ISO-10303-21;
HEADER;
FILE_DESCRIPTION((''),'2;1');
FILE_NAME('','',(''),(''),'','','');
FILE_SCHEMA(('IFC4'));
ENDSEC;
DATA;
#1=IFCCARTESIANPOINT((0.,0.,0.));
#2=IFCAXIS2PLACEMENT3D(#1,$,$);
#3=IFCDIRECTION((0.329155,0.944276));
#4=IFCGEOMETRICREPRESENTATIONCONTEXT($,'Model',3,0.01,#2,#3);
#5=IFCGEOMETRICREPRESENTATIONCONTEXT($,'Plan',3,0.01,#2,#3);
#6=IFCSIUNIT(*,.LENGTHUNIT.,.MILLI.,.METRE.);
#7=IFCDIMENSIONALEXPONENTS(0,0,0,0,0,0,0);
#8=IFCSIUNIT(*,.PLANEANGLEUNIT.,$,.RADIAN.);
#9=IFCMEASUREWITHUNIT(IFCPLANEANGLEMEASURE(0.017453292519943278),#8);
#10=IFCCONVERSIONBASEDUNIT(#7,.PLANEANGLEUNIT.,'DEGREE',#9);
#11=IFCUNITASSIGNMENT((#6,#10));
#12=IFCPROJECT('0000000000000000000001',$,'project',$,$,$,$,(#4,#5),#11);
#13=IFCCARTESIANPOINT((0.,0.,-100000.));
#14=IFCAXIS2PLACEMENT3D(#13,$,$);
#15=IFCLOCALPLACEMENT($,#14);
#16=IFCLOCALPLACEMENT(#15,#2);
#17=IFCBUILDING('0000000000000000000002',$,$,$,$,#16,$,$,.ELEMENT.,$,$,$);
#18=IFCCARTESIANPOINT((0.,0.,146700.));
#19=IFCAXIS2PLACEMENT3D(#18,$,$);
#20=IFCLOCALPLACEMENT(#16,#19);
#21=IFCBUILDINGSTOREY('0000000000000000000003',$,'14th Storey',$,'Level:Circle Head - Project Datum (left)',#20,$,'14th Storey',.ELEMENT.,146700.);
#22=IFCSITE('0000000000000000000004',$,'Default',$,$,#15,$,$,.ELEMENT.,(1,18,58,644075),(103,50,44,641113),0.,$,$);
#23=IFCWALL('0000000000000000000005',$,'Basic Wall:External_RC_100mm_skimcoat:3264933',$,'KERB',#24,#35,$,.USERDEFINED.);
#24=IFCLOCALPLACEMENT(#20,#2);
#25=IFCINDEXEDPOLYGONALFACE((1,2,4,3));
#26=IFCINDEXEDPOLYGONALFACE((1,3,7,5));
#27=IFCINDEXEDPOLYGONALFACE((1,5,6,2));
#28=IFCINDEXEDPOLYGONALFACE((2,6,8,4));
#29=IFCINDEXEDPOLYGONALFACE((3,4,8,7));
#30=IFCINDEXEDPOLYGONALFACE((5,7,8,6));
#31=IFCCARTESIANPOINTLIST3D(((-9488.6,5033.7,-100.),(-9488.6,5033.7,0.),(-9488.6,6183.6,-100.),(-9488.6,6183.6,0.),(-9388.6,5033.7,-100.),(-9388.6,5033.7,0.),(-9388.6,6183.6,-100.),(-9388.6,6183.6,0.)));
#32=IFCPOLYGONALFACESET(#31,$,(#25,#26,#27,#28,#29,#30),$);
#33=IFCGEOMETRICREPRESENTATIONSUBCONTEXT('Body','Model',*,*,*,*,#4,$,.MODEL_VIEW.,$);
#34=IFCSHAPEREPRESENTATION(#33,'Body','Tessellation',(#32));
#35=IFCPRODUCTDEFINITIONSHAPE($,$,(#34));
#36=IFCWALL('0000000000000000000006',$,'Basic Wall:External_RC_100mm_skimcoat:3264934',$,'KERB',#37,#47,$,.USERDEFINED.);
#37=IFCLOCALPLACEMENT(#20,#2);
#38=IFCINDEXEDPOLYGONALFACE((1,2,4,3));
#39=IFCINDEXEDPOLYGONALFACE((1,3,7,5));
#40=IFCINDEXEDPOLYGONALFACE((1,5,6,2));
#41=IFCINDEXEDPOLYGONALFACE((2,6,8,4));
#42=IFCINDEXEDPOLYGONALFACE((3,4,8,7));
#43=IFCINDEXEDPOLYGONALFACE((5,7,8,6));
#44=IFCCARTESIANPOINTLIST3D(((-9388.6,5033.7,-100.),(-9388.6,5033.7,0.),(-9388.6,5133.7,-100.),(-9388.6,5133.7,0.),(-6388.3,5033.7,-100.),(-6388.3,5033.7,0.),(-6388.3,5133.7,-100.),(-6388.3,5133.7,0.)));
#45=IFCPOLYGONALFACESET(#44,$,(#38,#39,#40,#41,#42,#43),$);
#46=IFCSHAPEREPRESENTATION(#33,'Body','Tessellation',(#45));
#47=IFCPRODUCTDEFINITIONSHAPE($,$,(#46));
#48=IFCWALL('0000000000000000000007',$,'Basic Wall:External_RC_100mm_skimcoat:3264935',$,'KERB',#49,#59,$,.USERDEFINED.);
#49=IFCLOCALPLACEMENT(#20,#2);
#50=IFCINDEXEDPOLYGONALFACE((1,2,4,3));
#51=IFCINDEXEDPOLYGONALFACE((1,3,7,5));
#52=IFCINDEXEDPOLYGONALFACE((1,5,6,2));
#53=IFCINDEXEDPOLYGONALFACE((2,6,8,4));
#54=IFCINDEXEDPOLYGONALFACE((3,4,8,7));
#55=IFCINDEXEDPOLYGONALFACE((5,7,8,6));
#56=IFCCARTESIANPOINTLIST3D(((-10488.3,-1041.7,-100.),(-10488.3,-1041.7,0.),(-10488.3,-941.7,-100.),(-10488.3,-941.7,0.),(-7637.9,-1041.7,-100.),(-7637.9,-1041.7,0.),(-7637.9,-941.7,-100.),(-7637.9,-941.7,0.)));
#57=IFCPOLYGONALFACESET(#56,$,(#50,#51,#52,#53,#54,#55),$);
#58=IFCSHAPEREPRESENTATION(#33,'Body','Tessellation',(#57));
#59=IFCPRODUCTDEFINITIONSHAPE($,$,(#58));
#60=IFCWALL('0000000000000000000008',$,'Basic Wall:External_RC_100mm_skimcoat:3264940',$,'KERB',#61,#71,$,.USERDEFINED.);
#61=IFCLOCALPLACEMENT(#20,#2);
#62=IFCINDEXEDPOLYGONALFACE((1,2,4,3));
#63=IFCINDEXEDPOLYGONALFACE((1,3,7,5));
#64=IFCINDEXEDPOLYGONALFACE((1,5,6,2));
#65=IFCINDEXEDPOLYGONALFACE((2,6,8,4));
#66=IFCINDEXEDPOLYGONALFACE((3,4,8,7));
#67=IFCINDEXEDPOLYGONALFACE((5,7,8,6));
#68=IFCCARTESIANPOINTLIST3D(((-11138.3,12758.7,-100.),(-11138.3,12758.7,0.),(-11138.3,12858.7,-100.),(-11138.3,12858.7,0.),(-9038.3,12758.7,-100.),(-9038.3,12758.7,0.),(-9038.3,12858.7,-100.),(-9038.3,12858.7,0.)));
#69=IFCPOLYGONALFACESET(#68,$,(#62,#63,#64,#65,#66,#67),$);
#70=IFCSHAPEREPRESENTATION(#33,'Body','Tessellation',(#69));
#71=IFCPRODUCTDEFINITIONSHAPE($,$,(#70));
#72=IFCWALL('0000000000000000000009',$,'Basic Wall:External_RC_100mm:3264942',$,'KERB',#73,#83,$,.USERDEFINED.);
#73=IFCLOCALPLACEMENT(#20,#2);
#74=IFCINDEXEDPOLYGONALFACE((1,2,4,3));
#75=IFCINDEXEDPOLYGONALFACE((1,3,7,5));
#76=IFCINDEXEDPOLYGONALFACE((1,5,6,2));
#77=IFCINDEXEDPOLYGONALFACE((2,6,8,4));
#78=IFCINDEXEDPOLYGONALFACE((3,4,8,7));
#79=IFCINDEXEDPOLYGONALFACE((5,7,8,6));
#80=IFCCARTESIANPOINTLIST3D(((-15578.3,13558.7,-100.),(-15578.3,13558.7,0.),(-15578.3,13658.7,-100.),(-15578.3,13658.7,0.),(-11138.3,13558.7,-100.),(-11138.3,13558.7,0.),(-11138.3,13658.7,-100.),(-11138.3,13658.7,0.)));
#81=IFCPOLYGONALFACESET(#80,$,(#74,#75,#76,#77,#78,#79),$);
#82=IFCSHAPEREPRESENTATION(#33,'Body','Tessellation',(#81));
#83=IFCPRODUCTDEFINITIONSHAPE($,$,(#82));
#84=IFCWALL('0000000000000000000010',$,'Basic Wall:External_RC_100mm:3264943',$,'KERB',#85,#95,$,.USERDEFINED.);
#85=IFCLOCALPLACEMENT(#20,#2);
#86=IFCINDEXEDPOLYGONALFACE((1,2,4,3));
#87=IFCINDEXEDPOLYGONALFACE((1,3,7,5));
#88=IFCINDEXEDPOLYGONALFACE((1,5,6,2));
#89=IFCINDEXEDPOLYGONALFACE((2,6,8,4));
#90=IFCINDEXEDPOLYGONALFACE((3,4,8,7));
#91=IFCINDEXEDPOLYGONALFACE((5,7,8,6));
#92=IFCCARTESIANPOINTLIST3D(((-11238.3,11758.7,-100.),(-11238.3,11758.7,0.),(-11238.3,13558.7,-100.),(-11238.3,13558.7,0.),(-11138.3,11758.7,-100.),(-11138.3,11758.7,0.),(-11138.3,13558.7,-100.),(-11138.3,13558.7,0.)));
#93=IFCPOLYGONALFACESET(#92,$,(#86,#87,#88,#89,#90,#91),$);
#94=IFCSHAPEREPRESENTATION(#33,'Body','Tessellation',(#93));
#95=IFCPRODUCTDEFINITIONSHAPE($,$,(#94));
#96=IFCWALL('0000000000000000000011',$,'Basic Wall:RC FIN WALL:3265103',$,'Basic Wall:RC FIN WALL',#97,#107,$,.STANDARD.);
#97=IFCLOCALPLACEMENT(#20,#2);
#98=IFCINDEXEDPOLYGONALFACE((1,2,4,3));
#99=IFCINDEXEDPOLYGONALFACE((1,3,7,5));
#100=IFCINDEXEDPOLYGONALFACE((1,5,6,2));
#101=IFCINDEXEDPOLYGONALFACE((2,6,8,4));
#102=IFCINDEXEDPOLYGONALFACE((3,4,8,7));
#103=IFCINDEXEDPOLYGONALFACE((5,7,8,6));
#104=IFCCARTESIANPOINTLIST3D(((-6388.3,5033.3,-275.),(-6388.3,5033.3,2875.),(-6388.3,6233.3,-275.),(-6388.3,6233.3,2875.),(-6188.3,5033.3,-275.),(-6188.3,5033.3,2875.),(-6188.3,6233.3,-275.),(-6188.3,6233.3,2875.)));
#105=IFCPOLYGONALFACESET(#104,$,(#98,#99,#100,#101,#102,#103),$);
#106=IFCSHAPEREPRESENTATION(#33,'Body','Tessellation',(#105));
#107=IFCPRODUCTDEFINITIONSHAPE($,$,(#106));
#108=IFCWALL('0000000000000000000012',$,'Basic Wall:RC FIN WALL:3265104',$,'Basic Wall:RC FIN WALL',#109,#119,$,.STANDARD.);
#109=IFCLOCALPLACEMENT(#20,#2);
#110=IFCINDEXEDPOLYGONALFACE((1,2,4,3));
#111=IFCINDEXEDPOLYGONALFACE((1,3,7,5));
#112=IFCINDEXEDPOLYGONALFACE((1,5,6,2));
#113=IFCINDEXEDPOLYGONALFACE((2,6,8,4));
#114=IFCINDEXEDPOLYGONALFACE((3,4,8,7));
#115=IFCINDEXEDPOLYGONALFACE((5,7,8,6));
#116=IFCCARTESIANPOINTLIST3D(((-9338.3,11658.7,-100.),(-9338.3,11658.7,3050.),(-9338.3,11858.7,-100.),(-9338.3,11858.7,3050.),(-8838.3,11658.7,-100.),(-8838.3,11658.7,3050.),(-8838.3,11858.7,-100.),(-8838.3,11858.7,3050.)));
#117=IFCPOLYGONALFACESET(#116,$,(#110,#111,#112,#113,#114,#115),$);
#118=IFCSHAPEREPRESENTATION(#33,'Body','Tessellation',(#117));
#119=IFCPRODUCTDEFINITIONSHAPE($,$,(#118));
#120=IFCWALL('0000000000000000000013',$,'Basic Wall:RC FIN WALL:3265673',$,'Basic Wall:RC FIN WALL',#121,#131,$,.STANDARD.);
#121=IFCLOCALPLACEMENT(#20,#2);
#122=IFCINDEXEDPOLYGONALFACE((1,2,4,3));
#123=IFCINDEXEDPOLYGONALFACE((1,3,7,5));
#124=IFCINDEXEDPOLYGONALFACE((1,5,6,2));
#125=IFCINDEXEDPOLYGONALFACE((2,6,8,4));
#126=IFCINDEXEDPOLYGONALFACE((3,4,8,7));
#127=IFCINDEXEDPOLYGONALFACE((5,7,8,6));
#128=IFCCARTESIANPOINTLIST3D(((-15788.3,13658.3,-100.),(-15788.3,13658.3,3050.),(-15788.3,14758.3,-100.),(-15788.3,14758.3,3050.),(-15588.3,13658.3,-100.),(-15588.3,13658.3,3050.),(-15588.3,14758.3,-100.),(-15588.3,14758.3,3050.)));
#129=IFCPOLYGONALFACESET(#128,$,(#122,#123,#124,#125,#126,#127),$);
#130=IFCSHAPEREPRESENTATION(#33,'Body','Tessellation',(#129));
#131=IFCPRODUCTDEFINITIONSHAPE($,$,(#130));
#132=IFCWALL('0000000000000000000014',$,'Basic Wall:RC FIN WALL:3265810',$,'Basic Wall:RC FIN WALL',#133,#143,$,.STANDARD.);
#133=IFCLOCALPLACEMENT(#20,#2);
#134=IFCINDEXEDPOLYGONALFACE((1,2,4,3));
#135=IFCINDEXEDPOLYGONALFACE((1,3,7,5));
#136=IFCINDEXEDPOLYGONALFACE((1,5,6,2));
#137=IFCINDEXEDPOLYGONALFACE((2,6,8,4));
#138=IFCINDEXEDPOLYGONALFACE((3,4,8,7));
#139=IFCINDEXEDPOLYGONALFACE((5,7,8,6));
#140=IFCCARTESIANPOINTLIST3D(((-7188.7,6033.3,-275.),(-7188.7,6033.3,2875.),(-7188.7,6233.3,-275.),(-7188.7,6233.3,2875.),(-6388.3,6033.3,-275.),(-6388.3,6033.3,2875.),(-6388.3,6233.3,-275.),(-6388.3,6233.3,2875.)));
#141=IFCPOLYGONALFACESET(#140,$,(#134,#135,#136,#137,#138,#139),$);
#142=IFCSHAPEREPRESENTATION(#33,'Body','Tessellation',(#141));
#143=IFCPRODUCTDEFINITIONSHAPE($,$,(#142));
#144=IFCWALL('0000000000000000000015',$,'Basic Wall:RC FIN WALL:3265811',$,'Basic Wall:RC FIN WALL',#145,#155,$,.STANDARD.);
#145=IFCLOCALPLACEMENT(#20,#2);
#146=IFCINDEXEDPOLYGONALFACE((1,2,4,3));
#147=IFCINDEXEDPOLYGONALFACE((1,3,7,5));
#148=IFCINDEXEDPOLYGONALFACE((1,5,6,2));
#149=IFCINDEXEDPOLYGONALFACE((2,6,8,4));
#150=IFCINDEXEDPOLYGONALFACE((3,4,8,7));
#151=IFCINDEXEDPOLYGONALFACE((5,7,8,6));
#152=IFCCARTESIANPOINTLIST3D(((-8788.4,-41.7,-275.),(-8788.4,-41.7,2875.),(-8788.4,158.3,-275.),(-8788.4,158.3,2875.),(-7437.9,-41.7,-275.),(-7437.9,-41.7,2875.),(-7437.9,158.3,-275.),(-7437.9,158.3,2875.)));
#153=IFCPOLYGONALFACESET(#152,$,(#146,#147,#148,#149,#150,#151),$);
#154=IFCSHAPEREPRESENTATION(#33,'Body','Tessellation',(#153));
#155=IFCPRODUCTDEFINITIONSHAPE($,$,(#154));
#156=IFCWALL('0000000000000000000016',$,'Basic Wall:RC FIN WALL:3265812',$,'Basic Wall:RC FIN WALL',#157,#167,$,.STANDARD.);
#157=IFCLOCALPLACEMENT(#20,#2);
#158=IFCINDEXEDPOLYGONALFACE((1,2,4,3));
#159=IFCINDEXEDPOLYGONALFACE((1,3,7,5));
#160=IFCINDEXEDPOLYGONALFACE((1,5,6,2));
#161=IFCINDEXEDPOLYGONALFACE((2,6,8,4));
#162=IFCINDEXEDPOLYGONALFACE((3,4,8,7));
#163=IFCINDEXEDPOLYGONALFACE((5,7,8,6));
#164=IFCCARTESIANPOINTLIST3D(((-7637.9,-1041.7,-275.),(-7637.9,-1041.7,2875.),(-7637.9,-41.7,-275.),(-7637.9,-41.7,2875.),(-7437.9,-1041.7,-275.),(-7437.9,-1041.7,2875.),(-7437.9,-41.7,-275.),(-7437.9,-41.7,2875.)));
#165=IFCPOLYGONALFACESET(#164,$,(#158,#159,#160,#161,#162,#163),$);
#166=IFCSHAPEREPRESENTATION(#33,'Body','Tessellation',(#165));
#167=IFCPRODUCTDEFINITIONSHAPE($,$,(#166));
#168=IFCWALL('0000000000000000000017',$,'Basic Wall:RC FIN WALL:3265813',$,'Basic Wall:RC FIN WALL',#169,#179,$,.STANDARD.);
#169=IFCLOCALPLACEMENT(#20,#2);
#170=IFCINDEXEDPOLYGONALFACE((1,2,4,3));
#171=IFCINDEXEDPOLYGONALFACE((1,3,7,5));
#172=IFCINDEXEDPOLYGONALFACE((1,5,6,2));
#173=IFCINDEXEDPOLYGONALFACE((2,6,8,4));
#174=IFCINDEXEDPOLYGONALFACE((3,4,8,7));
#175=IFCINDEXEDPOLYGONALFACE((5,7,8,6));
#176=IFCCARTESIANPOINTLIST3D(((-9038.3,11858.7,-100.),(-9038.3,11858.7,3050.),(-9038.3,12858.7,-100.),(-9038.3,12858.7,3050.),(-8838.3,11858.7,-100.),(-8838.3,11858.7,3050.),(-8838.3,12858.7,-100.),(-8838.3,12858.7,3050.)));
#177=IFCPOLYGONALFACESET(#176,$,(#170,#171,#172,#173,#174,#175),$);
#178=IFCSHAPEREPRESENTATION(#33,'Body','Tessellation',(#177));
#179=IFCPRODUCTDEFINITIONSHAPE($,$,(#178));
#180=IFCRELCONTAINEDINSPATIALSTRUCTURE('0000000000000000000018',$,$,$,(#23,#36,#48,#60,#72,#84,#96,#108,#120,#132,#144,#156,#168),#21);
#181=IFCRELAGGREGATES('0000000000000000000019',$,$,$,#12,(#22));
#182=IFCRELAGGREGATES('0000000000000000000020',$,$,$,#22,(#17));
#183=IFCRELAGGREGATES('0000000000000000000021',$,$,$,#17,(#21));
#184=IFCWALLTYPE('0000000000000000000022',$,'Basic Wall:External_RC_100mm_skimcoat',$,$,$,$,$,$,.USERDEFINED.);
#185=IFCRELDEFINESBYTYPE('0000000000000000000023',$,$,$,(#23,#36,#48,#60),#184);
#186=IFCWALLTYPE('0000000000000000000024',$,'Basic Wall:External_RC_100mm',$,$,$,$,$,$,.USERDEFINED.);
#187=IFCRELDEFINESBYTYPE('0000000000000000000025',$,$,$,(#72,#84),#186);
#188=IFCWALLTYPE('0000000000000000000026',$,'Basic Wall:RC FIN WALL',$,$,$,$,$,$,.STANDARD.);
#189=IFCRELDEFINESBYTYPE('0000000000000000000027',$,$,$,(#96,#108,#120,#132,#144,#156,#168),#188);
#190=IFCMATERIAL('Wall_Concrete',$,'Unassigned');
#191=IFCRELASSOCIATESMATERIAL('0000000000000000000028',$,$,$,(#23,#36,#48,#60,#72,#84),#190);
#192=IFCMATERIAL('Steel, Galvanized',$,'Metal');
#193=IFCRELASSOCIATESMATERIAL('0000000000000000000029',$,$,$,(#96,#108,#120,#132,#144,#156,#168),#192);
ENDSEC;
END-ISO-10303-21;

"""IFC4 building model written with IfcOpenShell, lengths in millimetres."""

from ifc_helpers import new_model, entity, si_unit, converted_unit, direction, frame, origin, place, context, subcontext, project, spatial, indexed_curve, outline, extrude, material, type_object, element, save


model = new_model("IFC4")

# Units and contexts
model_context = context("Model", 3, precision=0.01, world=origin(), true_north=direction((0.329155, 0.944276)))
plan_context = context("Plan", 3, precision=0.01, world=origin(), true_north=direction((0.329155, 0.944276)))
body_context = subcontext(model_context, "Body", "Model", "MODEL_VIEW")
ifc_project = project(units=[si_unit("LENGTHUNIT", "METRE", prefix="MILLI"), converted_unit("PLANEANGLEUNIT", "DEGREE", entity("IfcPlaneAngleMeasure", 0.017453292519943278), si_unit("PLANEANGLEUNIT", "RADIAN"), dimensions=[0, 0, 0, 0, 0, 0, 0])], contexts=[model_context, plan_context])

# Site, building, storey
site_placement = place(None, frame((0.0, 0.0, -100000.0)))
site = spatial("IfcSite", under=ifc_project, at=site_placement, Name="Default", CompositionType="ELEMENT", RefLatitude=(1, 18, 58, 644075), RefLongitude=(103, 50, 44, 641113), RefElevation=0.0)
building_placement = place(site_placement, origin())
building = spatial("IfcBuilding", under=site, at=building_placement, CompositionType="ELEMENT")
storey_placement = place(building_placement, frame((0.0, 0.0, 146700.0)))
storey = spatial("IfcBuildingStorey", under=building, at=storey_placement, Name="14th Storey", ObjectType="Level:Circle Head - Project Datum (left)", LongName="14th Storey", CompositionType="ELEMENT", Elevation=146700.0)

# Walls
ifc_material_1 = material(Name="Wall_Concrete", Category="Unassigned")
wall_type_1 = type_object("IfcWallType", Name="Basic Wall:External_RC_100mm_skimcoat", PredefinedType="USERDEFINED")
wall_1_placement = place(storey_placement, frame((-9438.6, 6183.6, -100.0), z_axis=(0.0, 0.0, 1.0), x_axis=(0.0, -1.0, 0.0)))
element("IfcWall", 1, at=wall_1_placement, inside=storey, type_object=wall_type_1, material=ifc_material_1, Name="Basic Wall:External_RC_100mm_skimcoat:3264933", ObjectType="KERB", PredefinedType="USERDEFINED", context=body_context, shape_type="SweptSolid", body=[
    extrude(outline(indexed_curve([(1149.9, 50.0), (0.0, 50.0), (0.0, -50.0), (1149.9, -50.0), (1149.9, 50.0)], self_intersect=False)), origin(), (0.0, 0.0, 1.0), 100.0),
])
wall_2_placement = place(storey_placement, frame((-9388.6, 5083.7, -100.0)))
element("IfcWall", 2, at=wall_2_placement, inside=storey, type_object=wall_type_1, material=ifc_material_1, Name="Basic Wall:External_RC_100mm_skimcoat:3264934", ObjectType="KERB", PredefinedType="USERDEFINED", context=body_context, shape_type="SweptSolid", body=[
    extrude(outline(indexed_curve([(3000.3, 50.0), (0.0, 50.0), (0.0, -50.0), (3000.3, -50.0), (3000.3, 50.0)], self_intersect=False)), origin(), (0.0, 0.0, 1.0), 100.0),
])
wall_3_placement = place(storey_placement, frame((-7637.9, -991.7, -100.0), z_axis=(0.0, 0.0, 1.0), x_axis=(-1.0, 0.0, 0.0)))
element("IfcWall", 3, at=wall_3_placement, inside=storey, type_object=wall_type_1, material=ifc_material_1, Name="Basic Wall:External_RC_100mm_skimcoat:3264935", ObjectType="KERB", PredefinedType="USERDEFINED", context=body_context, shape_type="SweptSolid", body=[
    extrude(outline(indexed_curve([(2850.5, 50.0), (0.0, 50.0), (0.0, -50.0), (2850.5, -50.0), (2850.5, 50.0)], self_intersect=False)), origin(), (0.0, 0.0, 1.0), 100.0),
])
wall_4_placement = place(storey_placement, frame((-9038.3, 12808.7, -100.0), z_axis=(0.0, 0.0, 1.0), x_axis=(-1.0, 0.0, 0.0)))
element("IfcWall", 4, at=wall_4_placement, inside=storey, type_object=wall_type_1, material=ifc_material_1, Name="Basic Wall:External_RC_100mm_skimcoat:3264940", ObjectType="KERB", PredefinedType="USERDEFINED", context=body_context, shape_type="SweptSolid", body=[
    extrude(outline(indexed_curve([(2100.0, 50.0), (0.0, 50.0), (0.0, -50.0), (2100.0, -50.0), (2100.0, 50.0)], self_intersect=False)), origin(), (0.0, 0.0, 1.0), 100.0),
])
wall_type_2 = type_object("IfcWallType", Name="Basic Wall:External_RC_100mm", PredefinedType="USERDEFINED")
wall_5_placement = place(storey_placement, frame((-15578.3, 13608.7, -100.0)))
element("IfcWall", 5, at=wall_5_placement, inside=storey, type_object=wall_type_2, material=ifc_material_1, Name="Basic Wall:External_RC_100mm:3264942", ObjectType="KERB", PredefinedType="USERDEFINED", context=body_context, shape_type="SweptSolid", body=[
    extrude(outline(indexed_curve([(4440.0, 50.0), (0.0, 50.0), (0.0, -50.0), (4440.0, -50.0), (4440.0, 50.0)], self_intersect=False)), origin(), (0.0, 0.0, 1.0), 100.0),
])
wall_6_placement = place(storey_placement, frame((-11188.3, 13558.7, -100.0), z_axis=(0.0, 0.0, 1.0), x_axis=(0.0, -1.0, 0.0)))
element("IfcWall", 6, at=wall_6_placement, inside=storey, type_object=wall_type_2, material=ifc_material_1, Name="Basic Wall:External_RC_100mm:3264943", ObjectType="KERB", PredefinedType="USERDEFINED", context=body_context, shape_type="SweptSolid", body=[
    extrude(outline(indexed_curve([(1800.0, 50.0), (0.0, 50.0), (0.0, -50.0), (1800.0, -50.0), (1800.0, 50.0)], self_intersect=False)), origin(), (0.0, 0.0, 1.0), 100.0),
])
ifc_material_2 = material(Name="Steel, Galvanized", Category="Metal")
wall_type_3 = type_object("IfcWallType", Name="Basic Wall:RC FIN WALL", PredefinedType="STANDARD")
wall_7_placement = place(storey_placement, frame((-6288.3, 6233.3, -275.0), z_axis=(0.0, 0.0, 1.0), x_axis=(0.0, -1.0, 0.0)))
element("IfcWall", 7, at=wall_7_placement, inside=storey, type_object=wall_type_3, material=ifc_material_2, Name="Basic Wall:RC FIN WALL:3265103", ObjectType="Basic Wall:RC FIN WALL", PredefinedType="STANDARD", context=body_context, shape_type="SweptSolid", body=[
    extrude(outline(indexed_curve([(1200.0, 100.0), (0.0, 100.0), (0.0, -100.0), (1200.0, -100.0), (1200.0, 100.0)], self_intersect=False)), origin(), (0.0, 0.0, 1.0), 3150.0),
])
wall_8_placement = place(storey_placement, frame((-9338.3, 11758.7, -100.0)))
element("IfcWall", 8, at=wall_8_placement, inside=storey, type_object=wall_type_3, material=ifc_material_2, Name="Basic Wall:RC FIN WALL:3265104", ObjectType="Basic Wall:RC FIN WALL", PredefinedType="STANDARD", context=body_context, shape_type="SweptSolid", body=[
    extrude(outline(indexed_curve([(500.0, 100.0), (0.0, 100.0), (0.0, -100.0), (500.0, -100.0), (500.0, 100.0)], self_intersect=False)), origin(), (0.0, 0.0, 1.0), 3150.0),
])
wall_9_placement = place(storey_placement, frame((-15688.3, 13658.3, -100.0), z_axis=(0.0, 0.0, 1.0), x_axis=(0.0, 1.0, 0.0)))
element("IfcWall", 9, at=wall_9_placement, inside=storey, type_object=wall_type_3, material=ifc_material_2, Name="Basic Wall:RC FIN WALL:3265673", ObjectType="Basic Wall:RC FIN WALL", PredefinedType="STANDARD", context=body_context, shape_type="SweptSolid", body=[
    extrude(outline(indexed_curve([(1100.0, 100.0), (0.0, 100.0), (0.0, -100.0), (1100.0, -100.0), (1100.0, 100.0)], self_intersect=False)), origin(), (0.0, 0.0, 1.0), 3150.0),
])
wall_10_placement = place(storey_placement, frame((-7188.7, 6133.3, -275.0)))
element("IfcWall", 10, at=wall_10_placement, inside=storey, type_object=wall_type_3, material=ifc_material_2, Name="Basic Wall:RC FIN WALL:3265810", ObjectType="Basic Wall:RC FIN WALL", PredefinedType="STANDARD", context=body_context, shape_type="SweptSolid", body=[
    extrude(outline(indexed_curve([(800.3, 100.0), (0.0, 100.0), (0.0, -100.0), (800.3, -100.0), (800.3, 100.0)], self_intersect=False)), origin(), (0.0, 0.0, 1.0), 3150.0),
])
wall_11_placement = place(storey_placement, frame((-8788.4, 58.3, -275.0)))
element("IfcWall", 11, at=wall_11_placement, inside=storey, type_object=wall_type_3, material=ifc_material_2, Name="Basic Wall:RC FIN WALL:3265811", ObjectType="Basic Wall:RC FIN WALL", PredefinedType="STANDARD", context=body_context, shape_type="SweptSolid", body=[
    extrude(outline(indexed_curve([(1350.5, 100.0), (0.0, 100.0), (0.0, -100.0), (1350.5, -100.0), (1350.5, 100.0)], self_intersect=False)), origin(), (0.0, 0.0, 1.0), 3150.0),
])
wall_12_placement = place(storey_placement, frame((-7537.9, -41.7, -275.0), z_axis=(0.0, 0.0, 1.0), x_axis=(0.0, -1.0, 0.0)))
element("IfcWall", 12, at=wall_12_placement, inside=storey, type_object=wall_type_3, material=ifc_material_2, Name="Basic Wall:RC FIN WALL:3265812", ObjectType="Basic Wall:RC FIN WALL", PredefinedType="STANDARD", context=body_context, shape_type="SweptSolid", body=[
    extrude(outline(indexed_curve([(1000.0, 100.0), (0.0, 100.0), (0.0, -100.0), (1000.0, -100.0), (1000.0, 100.0)], self_intersect=False)), origin(), (0.0, 0.0, 1.0), 3150.0),
])
wall_13_placement = place(storey_placement, frame((-8938.3, 11858.7, -100.0), z_axis=(0.0, 0.0, 1.0), x_axis=(0.0, 1.0, 0.0)))
element("IfcWall", 13, at=wall_13_placement, inside=storey, type_object=wall_type_3, material=ifc_material_2, Name="Basic Wall:RC FIN WALL:3265813", ObjectType="Basic Wall:RC FIN WALL", PredefinedType="STANDARD", context=body_context, shape_type="SweptSolid", body=[
    extrude(outline(indexed_curve([(1000.0, 100.0), (0.0, 100.0), (0.0, -100.0), (1000.0, -100.0), (1000.0, 100.0)], self_intersect=False)), origin(), (0.0, 0.0, 1.0), 3150.0),
])

save(model, "model.ifc")
